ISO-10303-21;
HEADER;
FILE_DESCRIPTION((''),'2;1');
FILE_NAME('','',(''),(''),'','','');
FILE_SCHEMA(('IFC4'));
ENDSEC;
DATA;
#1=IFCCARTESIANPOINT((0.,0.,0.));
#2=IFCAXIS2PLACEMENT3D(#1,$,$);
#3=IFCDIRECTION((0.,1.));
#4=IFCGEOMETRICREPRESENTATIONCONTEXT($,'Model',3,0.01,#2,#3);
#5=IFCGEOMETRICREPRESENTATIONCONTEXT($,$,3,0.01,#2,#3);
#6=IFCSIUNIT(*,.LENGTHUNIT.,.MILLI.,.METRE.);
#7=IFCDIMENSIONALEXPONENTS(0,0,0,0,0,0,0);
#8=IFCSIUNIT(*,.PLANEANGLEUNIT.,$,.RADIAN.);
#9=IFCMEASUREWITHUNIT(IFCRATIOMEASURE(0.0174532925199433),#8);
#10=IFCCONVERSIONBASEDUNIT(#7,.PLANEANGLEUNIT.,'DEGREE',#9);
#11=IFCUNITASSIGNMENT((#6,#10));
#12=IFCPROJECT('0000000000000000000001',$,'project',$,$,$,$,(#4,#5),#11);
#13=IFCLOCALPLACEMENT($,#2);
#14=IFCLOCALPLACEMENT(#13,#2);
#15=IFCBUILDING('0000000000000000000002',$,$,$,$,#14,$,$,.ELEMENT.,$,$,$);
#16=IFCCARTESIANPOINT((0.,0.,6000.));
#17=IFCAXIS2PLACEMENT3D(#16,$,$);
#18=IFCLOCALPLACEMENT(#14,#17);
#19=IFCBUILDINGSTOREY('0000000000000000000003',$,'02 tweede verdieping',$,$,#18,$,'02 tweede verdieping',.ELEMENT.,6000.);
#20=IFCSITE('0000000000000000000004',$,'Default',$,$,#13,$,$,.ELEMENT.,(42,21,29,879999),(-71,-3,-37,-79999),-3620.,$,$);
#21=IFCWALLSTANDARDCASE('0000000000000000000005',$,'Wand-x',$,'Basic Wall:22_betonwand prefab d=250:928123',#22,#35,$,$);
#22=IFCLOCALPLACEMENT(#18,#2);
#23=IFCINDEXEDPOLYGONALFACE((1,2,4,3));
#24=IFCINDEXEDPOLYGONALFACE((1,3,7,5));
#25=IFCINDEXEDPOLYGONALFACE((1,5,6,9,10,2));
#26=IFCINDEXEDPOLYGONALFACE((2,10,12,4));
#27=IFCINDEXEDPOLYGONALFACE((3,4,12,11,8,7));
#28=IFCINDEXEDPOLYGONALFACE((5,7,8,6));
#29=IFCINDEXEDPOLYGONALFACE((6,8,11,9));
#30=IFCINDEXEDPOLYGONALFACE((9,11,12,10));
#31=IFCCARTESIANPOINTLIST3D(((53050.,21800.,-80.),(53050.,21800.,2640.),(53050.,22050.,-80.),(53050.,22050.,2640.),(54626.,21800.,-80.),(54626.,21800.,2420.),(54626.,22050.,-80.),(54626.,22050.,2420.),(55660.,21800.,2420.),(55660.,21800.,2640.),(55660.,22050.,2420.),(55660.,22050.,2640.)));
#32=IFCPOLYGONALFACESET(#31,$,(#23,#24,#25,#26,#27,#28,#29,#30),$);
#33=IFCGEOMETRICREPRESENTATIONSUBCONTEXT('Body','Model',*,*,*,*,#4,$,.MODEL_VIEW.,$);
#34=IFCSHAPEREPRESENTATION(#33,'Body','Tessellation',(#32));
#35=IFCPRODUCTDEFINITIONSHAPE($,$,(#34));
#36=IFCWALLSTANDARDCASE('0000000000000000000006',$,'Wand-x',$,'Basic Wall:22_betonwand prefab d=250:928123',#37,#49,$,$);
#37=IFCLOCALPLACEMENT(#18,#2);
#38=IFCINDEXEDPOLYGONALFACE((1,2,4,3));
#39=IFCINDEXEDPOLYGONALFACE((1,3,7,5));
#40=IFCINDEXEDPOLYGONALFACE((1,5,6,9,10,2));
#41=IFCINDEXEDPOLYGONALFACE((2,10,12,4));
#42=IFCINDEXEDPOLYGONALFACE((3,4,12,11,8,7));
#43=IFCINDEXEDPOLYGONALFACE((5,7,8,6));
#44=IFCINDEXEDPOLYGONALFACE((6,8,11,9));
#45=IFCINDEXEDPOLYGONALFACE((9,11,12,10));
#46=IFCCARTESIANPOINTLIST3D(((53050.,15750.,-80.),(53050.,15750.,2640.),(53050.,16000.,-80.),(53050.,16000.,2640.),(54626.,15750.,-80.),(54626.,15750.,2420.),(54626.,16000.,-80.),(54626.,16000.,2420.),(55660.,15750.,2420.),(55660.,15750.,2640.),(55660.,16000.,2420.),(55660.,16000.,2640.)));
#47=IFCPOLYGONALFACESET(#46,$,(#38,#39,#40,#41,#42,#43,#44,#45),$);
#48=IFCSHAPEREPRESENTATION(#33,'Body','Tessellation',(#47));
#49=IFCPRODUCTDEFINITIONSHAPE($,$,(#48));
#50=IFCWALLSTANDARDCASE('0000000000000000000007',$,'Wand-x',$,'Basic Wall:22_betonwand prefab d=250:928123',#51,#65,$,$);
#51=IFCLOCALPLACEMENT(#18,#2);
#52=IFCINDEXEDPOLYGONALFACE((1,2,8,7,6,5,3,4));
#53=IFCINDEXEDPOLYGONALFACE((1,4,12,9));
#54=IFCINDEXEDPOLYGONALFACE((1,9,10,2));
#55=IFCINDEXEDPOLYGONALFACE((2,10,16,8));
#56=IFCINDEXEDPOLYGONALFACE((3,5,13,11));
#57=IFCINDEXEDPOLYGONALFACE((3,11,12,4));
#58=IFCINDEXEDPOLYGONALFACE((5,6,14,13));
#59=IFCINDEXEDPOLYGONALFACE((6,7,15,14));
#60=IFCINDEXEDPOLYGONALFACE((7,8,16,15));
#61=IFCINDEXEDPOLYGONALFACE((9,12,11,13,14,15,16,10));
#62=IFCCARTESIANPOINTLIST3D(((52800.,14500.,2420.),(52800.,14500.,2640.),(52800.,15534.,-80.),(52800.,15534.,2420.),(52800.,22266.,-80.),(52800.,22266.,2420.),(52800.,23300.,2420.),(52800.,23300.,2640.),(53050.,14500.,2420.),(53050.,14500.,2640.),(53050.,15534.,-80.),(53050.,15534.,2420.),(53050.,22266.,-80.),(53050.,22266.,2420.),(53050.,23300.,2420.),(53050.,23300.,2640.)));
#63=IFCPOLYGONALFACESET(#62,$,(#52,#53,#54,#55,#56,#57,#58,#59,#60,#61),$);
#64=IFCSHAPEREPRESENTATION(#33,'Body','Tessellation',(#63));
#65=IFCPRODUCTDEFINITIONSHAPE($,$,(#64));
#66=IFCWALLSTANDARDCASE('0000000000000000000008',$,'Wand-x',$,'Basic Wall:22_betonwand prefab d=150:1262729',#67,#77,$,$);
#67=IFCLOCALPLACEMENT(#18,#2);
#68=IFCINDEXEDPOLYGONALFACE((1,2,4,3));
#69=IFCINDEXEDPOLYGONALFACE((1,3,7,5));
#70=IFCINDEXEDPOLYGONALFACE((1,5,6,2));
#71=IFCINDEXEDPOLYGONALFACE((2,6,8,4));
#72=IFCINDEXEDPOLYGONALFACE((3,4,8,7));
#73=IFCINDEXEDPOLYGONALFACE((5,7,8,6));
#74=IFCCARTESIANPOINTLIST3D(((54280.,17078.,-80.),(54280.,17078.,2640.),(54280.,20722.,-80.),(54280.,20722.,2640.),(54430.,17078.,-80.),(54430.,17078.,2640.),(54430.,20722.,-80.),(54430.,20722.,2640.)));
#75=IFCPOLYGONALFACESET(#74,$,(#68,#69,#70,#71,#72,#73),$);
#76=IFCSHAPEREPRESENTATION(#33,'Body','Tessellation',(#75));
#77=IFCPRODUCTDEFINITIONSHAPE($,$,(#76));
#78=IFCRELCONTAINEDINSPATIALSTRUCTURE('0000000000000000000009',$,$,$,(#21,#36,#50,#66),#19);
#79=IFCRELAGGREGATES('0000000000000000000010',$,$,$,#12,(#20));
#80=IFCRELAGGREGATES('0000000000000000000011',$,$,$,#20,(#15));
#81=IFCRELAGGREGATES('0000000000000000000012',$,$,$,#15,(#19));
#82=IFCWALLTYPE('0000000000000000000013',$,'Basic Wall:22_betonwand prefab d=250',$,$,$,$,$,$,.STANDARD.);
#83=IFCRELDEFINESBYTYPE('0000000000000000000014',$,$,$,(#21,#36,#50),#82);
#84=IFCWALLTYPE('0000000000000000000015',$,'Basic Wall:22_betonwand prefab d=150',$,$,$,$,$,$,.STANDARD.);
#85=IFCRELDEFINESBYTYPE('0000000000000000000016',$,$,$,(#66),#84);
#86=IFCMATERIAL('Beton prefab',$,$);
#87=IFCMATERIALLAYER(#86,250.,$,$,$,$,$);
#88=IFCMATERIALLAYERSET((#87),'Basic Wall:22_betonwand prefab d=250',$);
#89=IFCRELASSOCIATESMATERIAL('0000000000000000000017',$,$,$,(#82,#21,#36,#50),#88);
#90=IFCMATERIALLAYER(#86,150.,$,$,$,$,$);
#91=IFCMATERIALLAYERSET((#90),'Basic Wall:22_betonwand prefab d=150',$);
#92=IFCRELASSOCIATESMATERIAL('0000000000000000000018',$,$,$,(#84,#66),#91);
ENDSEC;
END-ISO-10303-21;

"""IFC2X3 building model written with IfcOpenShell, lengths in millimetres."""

from ifc_helpers import new_model, entity, si_unit, converted_unit, direction, frame, frame_2d, origin, place, context, subcontext, project, spatial, rectangle, extrude, material, layer, layer_set, layer_usage, type_object, element, save


model = new_model("IFC2X3")

# Units and contexts
model_context = context("Model", 3, precision=0.01, world=origin(), true_north=direction((0.0, 1.0)))
context_of_model = context(None, 3, precision=0.01, world=origin(), true_north=direction((0.0, 1.0)))
body_context = subcontext(model_context, "Body", "Model", "MODEL_VIEW")
ifc_project = project(units=[si_unit("LENGTHUNIT", "METRE", prefix="MILLI"), converted_unit("PLANEANGLEUNIT", "DEGREE", entity("IfcRatioMeasure", 0.0174532925199433), si_unit("PLANEANGLEUNIT", "RADIAN"), dimensions=[0, 0, 0, 0, 0, 0, 0])], contexts=[model_context, context_of_model])

# Site, building, storey
site_placement = place(None, origin())
site = spatial("IfcSite", under=ifc_project, at=site_placement, Name="Default", CompositionType="ELEMENT", RefLatitude=(42, 21, 29, 879999), RefLongitude=(-71, -3, -37, -79999), RefElevation=-3620.0)
building_placement = place(site_placement, origin())
building = spatial("IfcBuilding", under=site, at=building_placement, CompositionType="ELEMENT")
storey_placement = place(building_placement, frame((0.0, 0.0, 6000.0)))
storey = spatial("IfcBuildingStorey", under=building, at=storey_placement, Name="02 tweede verdieping", LongName="02 tweede verdieping", CompositionType="ELEMENT", Elevation=6000.0)

# Shared definitions
ifc_material_1 = material(Name="Beton prefab")

# Walls, openings
ifc_layer_1 = layer(ifc_material_1, 250.0)
ifc_layer_set_1 = layer_set([ifc_layer_1], Name="Basic Wall:22_betonwand prefab d=250")
ifc_layer_usage_1 = layer_usage(ifc_layer_set_1, "AXIS2", "NEGATIVE", 125.0)
wall_type_1 = type_object("IfcWallType", Name="Basic Wall:22_betonwand prefab d=250", PredefinedType="STANDARD", material=ifc_layer_set_1)
wall_1_placement = place(storey_placement, frame((53050.0, 21925.0, -80.0)))
wall_1 = element("IfcWallStandardCase", 1, at=wall_1_placement, inside=storey, type_object=wall_type_1, material=ifc_layer_usage_1, Name="Wand-x", ObjectType="Basic Wall:22_betonwand prefab d=250:928123", context=body_context, shape_type="SweptSolid", body=[
    extrude(rectangle(XDim=2610.0, YDim=250.0, at=frame_2d((1305.0, 0.0), x_axis=(-1.0, 0.0))), origin(), (0.0, 0.0, 1.0), 2720.0),
])
opening_1_placement = place(wall_1_placement, frame((-53050.0, -21925.0, 80.0)))
element("IfcOpeningElement", 2, at=opening_1_placement, cuts=wall_1, ObjectType="Opening", context=body_context, shape_type="SweptSolid", body=[
    extrude(rectangle(XDim=2500.0, YDim=1034.0, at=frame_2d((0.0, 0.0), x_axis=(1.0, 0.0))), frame((55143.0, 21525.0, 1170.0), z_axis=(0.0, 1.0, 0.0), x_axis=(0.0, 0.0, -1.0)), (0.0, 0.0, 1.0), 800.0),
])
ifc_layer_usage_2 = layer_usage(ifc_layer_set_1, "AXIS2", "POSITIVE", -125.0)
wall_2_placement = place(storey_placement, frame((53050.0, 15875.0, -80.0)))
wall_2 = element("IfcWallStandardCase", 3, at=wall_2_placement, inside=storey, type_object=wall_type_1, material=ifc_layer_usage_2, Name="Wand-x", ObjectType="Basic Wall:22_betonwand prefab d=250:928123", context=body_context, shape_type="SweptSolid", body=[
    extrude(rectangle(XDim=2610.0, YDim=250.0, at=frame_2d((1305.0, 0.0), x_axis=(-1.0, 0.0))), origin(), (0.0, 0.0, 1.0), 2720.0),
])
opening_2_placement = place(wall_2_placement, frame((-53050.0, -15875.0, 80.0)))
element("IfcOpeningElement", 4, at=opening_2_placement, cuts=wall_2, ObjectType="Opening", context=body_context, shape_type="SweptSolid", body=[
    extrude(rectangle(XDim=2500.0, YDim=1034.0, at=frame_2d((0.0, 0.0), x_axis=(1.0, 0.0))), frame((55143.0, 15475.0, 1170.0), z_axis=(0.0, 1.0, 0.0), x_axis=(0.0, 0.0, -1.0)), (0.0, 0.0, 1.0), 800.0),
])

# Wall, openings
ifc_layer_usage_3 = layer_usage(ifc_layer_set_1, "AXIS2", "NEGATIVE", 125.0)
wall_3_placement = place(storey_placement, frame((52925.0, 14500.0, -80.0), z_axis=(0.0, 0.0, 1.0), x_axis=(0.0, 1.0, 0.0)))
wall_3 = element("IfcWallStandardCase", 5, at=wall_3_placement, inside=storey, type_object=wall_type_1, material=ifc_layer_usage_3, Name="Wand-x", ObjectType="Basic Wall:22_betonwand prefab d=250:928123", context=body_context, shape_type="SweptSolid", body=[
    extrude(rectangle(XDim=8800.0, YDim=250.0, at=frame_2d((4400.0, 0.0), x_axis=(-1.0, 0.0))), origin(), (0.0, 0.0, 1.0), 2720.0),
])
opening_3_placement = place(wall_3_placement, frame((-14500.0, 52925.0, 80.0), z_axis=(0.0, 0.0, 1.0), x_axis=(0.0, -1.0, 0.0)))
element("IfcOpeningElement", 6, at=opening_3_placement, cuts=wall_3, ObjectType="Opening", context=body_context, shape_type="SweptSolid", body=[
    extrude(rectangle(XDim=2500.0, YDim=1034.0, at=frame_2d((0.0, 0.0), x_axis=(1.0, 0.0))), frame((53325.0, 15017.0, 1170.0), z_axis=(-1.0, 0.0, 0.0), x_axis=(0.0, 0.0, -1.0)), (0.0, 0.0, 1.0), 800.0),
])
opening_4_placement = place(wall_3_placement, frame((-14500.0, 52925.0, 80.0), z_axis=(0.0, 0.0, 1.0), x_axis=(0.0, -1.0, 0.0)))
element("IfcOpeningElement", 7, at=opening_4_placement, cuts=wall_3, ObjectType="Opening", context=body_context, shape_type="SweptSolid", body=[
    extrude(rectangle(XDim=2500.0, YDim=1034.0, at=frame_2d((0.0, 0.0), x_axis=(0.0, 1.0))), frame((53325.0, 22783.0, 1170.0), z_axis=(-1.0, 0.0, 0.0), x_axis=(0.0, 1.0, 0.0)), (0.0, 0.0, 1.0), 800.0),
])

# Wall
ifc_layer_2 = layer(ifc_material_1, 150.0)
ifc_layer_set_2 = layer_set([ifc_layer_2], Name="Basic Wall:22_betonwand prefab d=150")
ifc_layer_usage_4 = layer_usage(ifc_layer_set_2, "AXIS2", "NEGATIVE", 75.0)
wall_type_2 = type_object("IfcWallType", Name="Basic Wall:22_betonwand prefab d=150", PredefinedType="STANDARD", material=ifc_layer_set_2)
wall_4_placement = place(storey_placement, frame((54355.0, 17078.0, -80.0), z_axis=(0.0, 0.0, 1.0), x_axis=(0.0, 1.0, 0.0)))
element("IfcWallStandardCase", 8, at=wall_4_placement, inside=storey, type_object=wall_type_2, material=ifc_layer_usage_4, Name="Wand-x", ObjectType="Basic Wall:22_betonwand prefab d=150:1262729", context=body_context, shape_type="SweptSolid", body=[
    extrude(rectangle(XDim=3644.0, YDim=150.0, at=frame_2d((1822.0, 0.0), x_axis=(-1.0, 0.0))), origin(), (0.0, 0.0, 1.0), 2720.0),
])

save(model, "model.ifc")
